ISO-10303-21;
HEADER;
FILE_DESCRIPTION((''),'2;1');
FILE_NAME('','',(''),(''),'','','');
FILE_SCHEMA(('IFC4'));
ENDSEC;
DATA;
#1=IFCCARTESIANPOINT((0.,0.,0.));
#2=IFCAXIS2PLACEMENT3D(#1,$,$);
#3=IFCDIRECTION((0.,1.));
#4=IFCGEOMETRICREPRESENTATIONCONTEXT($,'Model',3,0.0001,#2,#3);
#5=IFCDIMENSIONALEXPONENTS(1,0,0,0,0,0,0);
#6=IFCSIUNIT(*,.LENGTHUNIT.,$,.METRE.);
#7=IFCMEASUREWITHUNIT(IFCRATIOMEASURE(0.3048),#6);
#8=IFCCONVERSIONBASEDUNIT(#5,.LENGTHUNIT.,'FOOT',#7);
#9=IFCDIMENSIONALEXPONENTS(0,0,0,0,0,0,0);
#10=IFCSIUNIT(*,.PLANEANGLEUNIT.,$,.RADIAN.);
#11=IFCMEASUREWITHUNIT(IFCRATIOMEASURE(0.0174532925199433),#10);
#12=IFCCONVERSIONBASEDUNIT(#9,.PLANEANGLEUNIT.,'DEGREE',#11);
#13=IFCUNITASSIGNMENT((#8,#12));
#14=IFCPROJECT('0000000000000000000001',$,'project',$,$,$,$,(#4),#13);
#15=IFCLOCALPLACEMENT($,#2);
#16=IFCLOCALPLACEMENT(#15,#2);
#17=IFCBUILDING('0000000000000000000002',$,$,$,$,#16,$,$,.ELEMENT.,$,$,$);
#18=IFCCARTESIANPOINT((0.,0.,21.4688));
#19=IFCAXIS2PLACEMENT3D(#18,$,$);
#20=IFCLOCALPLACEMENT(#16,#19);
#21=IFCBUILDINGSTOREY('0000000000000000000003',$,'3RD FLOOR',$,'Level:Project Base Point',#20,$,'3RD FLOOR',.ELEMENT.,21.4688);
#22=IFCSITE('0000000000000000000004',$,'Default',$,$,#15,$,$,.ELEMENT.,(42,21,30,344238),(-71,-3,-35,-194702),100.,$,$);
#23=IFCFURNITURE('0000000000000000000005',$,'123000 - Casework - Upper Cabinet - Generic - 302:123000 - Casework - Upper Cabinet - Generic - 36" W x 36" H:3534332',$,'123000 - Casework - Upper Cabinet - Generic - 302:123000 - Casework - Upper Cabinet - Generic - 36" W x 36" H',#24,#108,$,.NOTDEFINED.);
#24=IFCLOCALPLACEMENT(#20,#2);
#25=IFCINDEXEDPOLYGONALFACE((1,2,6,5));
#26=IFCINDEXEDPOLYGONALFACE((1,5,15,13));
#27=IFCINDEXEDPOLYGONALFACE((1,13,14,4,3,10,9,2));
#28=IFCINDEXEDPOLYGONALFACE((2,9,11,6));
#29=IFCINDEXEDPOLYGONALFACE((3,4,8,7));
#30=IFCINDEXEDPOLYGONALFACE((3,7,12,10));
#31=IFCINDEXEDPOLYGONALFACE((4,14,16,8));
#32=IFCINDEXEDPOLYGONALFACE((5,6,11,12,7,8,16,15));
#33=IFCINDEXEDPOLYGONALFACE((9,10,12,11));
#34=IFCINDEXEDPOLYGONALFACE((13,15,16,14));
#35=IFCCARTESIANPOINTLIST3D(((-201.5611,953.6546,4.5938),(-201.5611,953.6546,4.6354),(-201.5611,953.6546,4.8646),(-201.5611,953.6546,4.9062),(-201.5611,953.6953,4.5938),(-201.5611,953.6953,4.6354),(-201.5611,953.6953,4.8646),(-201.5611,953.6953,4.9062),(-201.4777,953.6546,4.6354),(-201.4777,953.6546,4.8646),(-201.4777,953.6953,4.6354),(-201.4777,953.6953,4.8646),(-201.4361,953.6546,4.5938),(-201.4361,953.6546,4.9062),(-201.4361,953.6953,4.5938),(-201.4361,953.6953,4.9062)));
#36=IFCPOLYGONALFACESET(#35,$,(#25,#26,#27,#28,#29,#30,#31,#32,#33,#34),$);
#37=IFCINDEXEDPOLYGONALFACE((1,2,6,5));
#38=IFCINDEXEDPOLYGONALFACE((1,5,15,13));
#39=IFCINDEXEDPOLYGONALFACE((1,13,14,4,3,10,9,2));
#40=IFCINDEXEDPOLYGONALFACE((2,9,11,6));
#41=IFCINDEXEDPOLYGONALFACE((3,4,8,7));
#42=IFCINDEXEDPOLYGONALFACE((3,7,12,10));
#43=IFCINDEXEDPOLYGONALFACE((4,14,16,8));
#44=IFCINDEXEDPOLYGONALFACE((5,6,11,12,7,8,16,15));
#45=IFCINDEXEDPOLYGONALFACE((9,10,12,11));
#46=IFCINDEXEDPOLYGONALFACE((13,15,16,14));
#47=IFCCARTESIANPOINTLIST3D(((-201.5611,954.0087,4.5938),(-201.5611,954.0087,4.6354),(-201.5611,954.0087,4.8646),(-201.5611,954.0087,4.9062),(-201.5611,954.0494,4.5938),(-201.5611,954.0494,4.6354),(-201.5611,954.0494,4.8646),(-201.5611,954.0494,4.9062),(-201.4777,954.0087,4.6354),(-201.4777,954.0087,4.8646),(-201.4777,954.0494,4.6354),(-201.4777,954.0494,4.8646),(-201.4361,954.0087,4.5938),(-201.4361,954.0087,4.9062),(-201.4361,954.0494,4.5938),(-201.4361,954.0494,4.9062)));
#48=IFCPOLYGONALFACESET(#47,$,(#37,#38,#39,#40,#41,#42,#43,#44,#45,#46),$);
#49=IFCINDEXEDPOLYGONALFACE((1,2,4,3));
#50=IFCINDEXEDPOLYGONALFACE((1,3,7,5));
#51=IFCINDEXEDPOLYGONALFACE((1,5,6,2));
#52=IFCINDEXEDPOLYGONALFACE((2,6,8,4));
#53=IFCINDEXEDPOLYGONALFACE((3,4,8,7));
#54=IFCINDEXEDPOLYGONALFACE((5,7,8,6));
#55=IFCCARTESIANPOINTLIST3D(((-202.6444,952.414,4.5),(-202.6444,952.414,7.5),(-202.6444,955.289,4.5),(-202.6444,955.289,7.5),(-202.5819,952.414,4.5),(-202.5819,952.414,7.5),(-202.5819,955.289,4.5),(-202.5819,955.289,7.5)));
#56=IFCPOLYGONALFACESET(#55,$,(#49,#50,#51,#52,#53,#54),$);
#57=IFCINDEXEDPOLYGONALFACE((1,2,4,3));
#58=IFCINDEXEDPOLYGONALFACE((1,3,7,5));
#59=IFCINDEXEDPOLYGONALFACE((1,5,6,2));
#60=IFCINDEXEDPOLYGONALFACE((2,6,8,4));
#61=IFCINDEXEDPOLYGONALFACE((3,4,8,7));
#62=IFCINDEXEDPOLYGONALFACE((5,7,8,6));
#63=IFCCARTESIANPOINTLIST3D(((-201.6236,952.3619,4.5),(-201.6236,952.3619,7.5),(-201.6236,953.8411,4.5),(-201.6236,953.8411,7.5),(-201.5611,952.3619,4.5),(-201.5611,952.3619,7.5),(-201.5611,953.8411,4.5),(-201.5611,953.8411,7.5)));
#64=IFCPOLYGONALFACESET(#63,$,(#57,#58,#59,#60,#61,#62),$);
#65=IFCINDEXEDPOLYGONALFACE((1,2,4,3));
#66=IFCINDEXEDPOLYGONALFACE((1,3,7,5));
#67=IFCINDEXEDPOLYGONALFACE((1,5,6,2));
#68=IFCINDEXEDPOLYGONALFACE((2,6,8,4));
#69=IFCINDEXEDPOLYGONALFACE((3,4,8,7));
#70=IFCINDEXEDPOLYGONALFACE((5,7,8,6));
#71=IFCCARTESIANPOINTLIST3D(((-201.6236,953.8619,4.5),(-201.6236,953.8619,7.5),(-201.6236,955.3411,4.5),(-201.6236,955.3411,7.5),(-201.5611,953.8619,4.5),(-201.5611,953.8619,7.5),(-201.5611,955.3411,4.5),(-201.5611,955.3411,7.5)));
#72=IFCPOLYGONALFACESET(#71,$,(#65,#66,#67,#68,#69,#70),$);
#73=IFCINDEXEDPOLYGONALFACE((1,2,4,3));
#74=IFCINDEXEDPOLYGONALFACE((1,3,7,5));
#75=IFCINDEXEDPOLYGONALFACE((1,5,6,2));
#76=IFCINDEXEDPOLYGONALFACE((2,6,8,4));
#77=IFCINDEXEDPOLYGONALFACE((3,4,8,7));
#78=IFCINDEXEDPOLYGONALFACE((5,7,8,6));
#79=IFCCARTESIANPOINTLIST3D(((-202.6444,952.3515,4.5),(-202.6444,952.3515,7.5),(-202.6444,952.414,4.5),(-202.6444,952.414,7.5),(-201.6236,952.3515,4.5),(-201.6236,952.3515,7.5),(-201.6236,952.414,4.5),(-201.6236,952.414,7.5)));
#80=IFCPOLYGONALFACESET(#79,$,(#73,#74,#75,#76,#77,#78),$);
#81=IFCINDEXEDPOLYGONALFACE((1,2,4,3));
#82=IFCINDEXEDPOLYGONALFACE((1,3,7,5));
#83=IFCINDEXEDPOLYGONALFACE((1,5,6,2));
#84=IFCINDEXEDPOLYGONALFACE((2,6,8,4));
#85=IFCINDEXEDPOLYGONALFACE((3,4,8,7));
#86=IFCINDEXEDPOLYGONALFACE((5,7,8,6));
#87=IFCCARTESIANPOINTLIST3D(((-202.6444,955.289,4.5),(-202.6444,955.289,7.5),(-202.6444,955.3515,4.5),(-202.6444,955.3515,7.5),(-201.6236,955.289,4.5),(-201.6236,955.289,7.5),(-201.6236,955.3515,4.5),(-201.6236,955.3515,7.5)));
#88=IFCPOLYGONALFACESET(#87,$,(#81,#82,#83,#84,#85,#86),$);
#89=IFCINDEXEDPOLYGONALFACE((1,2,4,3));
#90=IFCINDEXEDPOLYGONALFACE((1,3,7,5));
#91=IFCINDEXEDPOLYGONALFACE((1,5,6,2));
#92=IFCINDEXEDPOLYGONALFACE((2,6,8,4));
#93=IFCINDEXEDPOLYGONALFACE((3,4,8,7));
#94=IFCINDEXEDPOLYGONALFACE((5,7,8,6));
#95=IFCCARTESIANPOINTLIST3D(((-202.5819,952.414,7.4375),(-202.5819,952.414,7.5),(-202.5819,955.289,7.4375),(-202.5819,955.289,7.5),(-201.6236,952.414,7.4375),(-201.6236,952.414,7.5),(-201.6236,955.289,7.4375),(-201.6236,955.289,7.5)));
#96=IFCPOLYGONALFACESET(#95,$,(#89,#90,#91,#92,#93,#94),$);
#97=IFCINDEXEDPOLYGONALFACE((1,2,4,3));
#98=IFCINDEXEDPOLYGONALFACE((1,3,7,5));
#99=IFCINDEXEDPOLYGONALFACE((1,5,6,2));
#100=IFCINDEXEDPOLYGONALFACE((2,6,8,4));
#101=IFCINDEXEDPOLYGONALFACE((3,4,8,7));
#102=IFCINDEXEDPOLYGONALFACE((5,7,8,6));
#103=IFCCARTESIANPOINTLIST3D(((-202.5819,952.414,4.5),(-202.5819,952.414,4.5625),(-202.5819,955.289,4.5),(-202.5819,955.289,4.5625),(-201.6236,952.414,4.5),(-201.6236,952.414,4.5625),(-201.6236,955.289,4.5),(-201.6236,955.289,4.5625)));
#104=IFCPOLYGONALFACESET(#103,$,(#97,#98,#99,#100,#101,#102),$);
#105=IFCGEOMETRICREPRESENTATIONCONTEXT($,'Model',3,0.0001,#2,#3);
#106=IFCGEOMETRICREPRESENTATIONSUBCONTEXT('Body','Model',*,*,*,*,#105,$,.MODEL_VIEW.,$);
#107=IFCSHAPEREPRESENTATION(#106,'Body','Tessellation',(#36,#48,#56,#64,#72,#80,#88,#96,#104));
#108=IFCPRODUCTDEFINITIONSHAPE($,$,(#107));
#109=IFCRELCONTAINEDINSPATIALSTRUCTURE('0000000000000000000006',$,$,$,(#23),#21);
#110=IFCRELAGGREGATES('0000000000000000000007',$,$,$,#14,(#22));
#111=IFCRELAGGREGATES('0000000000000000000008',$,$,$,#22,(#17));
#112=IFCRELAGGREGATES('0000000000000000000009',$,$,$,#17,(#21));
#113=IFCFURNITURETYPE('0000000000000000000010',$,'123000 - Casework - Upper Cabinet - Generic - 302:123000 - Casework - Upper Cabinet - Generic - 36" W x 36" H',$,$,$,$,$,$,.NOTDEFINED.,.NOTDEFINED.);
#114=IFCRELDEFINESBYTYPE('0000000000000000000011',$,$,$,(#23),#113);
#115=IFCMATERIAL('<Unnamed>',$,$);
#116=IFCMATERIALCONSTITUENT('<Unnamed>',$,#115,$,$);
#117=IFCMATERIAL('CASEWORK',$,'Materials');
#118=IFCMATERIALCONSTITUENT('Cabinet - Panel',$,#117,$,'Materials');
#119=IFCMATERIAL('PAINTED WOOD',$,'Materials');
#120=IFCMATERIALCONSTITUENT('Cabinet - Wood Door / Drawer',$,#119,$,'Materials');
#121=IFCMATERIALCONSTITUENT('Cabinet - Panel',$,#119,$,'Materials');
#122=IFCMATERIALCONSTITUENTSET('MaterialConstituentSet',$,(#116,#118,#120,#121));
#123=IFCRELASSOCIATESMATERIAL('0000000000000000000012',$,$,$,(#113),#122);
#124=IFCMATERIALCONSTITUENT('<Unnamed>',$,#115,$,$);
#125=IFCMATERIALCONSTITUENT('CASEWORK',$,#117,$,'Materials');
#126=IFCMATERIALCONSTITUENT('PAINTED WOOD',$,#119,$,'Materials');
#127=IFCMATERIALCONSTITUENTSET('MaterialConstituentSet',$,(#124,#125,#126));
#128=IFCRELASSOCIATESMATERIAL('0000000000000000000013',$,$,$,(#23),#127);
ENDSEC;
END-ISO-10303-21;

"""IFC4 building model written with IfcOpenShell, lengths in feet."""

from ifc_helpers import new_model, entity, si_unit, converted_unit, direction, frame, frame_2d, origin, origin_2d_with_axis, place, context, subcontext, project, spatial, polyline, rectangle, outline, extrude, source, transform, mapped, material, constituent, constituent_set, type_object, type_shapes, element, save


model = new_model("IFC4")

# Units and contexts
model_context_1 = context("Model", 3, precision=0.0001, world=origin(), true_north=direction((0.0, 1.0)))
model_context_2 = context("Model", 3, precision=0.0001, world=origin(), true_north=direction((0.0, 1.0)))
body_context = subcontext(model_context_2, "Body", "Model", "MODEL_VIEW")
ifc_project = project(units=[converted_unit("LENGTHUNIT", "FOOT", entity("IfcRatioMeasure", 0.3048), si_unit("LENGTHUNIT", "METRE"), dimensions=[1, 0, 0, 0, 0, 0, 0]), converted_unit("PLANEANGLEUNIT", "DEGREE", entity("IfcRatioMeasure", 0.0174532925199433), si_unit("PLANEANGLEUNIT", "RADIAN"), dimensions=[0, 0, 0, 0, 0, 0, 0])], contexts=[model_context_1])

# Site, building, storey
site_placement = place(None, origin())
site = spatial("IfcSite", under=ifc_project, at=site_placement, Name="Default", CompositionType="ELEMENT", RefLatitude=(42, 21, 30, 344238), RefLongitude=(-71, -3, -35, -194702), RefElevation=100.0)
building_placement = place(site_placement, origin())
building = spatial("IfcBuilding", under=site, at=building_placement, CompositionType="ELEMENT")
storey_placement = place(building_placement, frame((0.0, 0.0, 21.4688)))
storey = spatial("IfcBuildingStorey", under=building, at=storey_placement, Name="3RD FLOOR", ObjectType="Level:Project Base Point", LongName="3RD FLOOR", CompositionType="ELEMENT", Elevation=21.4688)

# Furniture
ifc_material_1 = material(Name="CASEWORK", Category="Materials")
ifc_material_2 = material(Name="PAINTED WOOD", Category="Materials")
ifc_material_3 = material(Name="<Unnamed>")
ifc_constituent_1 = constituent(ifc_material_3, Name="<Unnamed>")
ifc_constituent_2 = constituent(ifc_material_1, Name="CASEWORK", Category="Materials")
ifc_constituent_3 = constituent(ifc_material_2, Name="PAINTED WOOD", Category="Materials")
ifc_constituent_set_1 = constituent_set(constituents=[ifc_constituent_1, ifc_constituent_2, ifc_constituent_3], Name="MaterialConstituentSet")
ifc_constituent_4 = constituent(ifc_material_3, Name="<Unnamed>")
ifc_constituent_5 = constituent(ifc_material_1, Name="Cabinet - Panel", Category="Materials")
ifc_constituent_6 = constituent(ifc_material_2, Name="Cabinet - Wood Door / Drawer", Category="Materials")
ifc_constituent_7 = constituent(ifc_material_2, Name="Cabinet - Panel", Category="Materials")
ifc_constituent_set_2 = constituent_set(constituents=[ifc_constituent_4, ifc_constituent_5, ifc_constituent_6, ifc_constituent_7], Name="MaterialConstituentSet")
furniture_type_1 = type_object("IfcFurnitureType", Name="123000 - Casework - Upper Cabinet - Generic - 302:123000 - Casework - Upper Cabinet - Generic - 36\" W x 36\" H", AssemblyPlace="NOTDEFINED", PredefinedType="NOTDEFINED", material=ifc_constituent_set_2)
shared_shape_1 = source(origin(), body_context, "Body", "SweptSolid", [
    extrude(outline(polyline([(0.1146, -0.0521), (0.1562, -0.0521), (0.1562, 0.0729), (-0.1562, 0.0729), (-0.1562, -0.0521), (-0.1146, -0.0521), (-0.1146, 0.0313), (0.1146, 0.0313), (0.1146, -0.0521)])), frame((1.303, 0.0729, 0.25), z_axis=(1.0, 0.0, 0.0), x_axis=(0.0, 0.0, 1.0)), (0.0, 0.0, 1.0), 0.0407),
    extrude(outline(polyline([(0.1146, -0.0521), (0.1562, -0.0521), (0.1562, 0.0729), (-0.1562, 0.0729), (-0.1562, -0.0521), (-0.1146, -0.0521), (-0.1146, 0.0313), (0.1146, 0.0313), (0.1146, -0.0521)])), frame((1.6572, 0.0729, 0.25), z_axis=(1.0, 0.0, 0.0), x_axis=(0.0, 0.0, 1.0)), (0.0, 0.0, 1.0), 0.0407),
    extrude(rectangle(XDim=0.0625, YDim=2.875, at=origin_2d_with_axis()), frame((1.5, 1.177, 0.0), z_axis=(0.0, 0.0, 1.0), x_axis=(0.0, 1.0, 0.0)), (0.0, 0.0, 1.0), 3.0),
    extrude(rectangle(XDim=0.0625, YDim=1.4792, at=frame_2d((0.0, 0.0), x_axis=(1.0, 0.0))), frame((0.75, 0.1562, 0.0), z_axis=(0.0, 0.0, 1.0), x_axis=(0.0, -1.0, 0.0)), (0.0, 0.0, 1.0), 3.0),
    extrude(rectangle(XDim=0.0625, YDim=1.4792, at=origin_2d_with_axis()), frame((2.25, 0.1562, 0.0), z_axis=(0.0, 0.0, 1.0), x_axis=(0.0, -1.0, 0.0)), (0.0, 0.0, 1.0), 3.0),
    extrude(rectangle(XDim=0.0625, YDim=1.0208, at=origin_2d_with_axis()), frame((0.0312, 0.6979, 0.0), z_axis=(0.0, 0.0, 1.0), x_axis=(-1.0, 0.0, 0.0)), (0.0, 0.0, 1.0), 3.0),
    extrude(rectangle(XDim=0.0625, YDim=1.0208, at=origin_2d_with_axis()), frame((2.9688, 0.6979, 0.0), z_axis=(0.0, 0.0, 1.0), x_axis=(-1.0, 0.0, 0.0)), (0.0, 0.0, 1.0), 3.0),
    extrude(rectangle(XDim=2.875, YDim=0.9583, at=frame_2d((0.0, 0.0), x_axis=(1.0, 0.0))), frame((1.5, 0.6666, 2.9375), z_axis=(0.0, 0.0, 1.0), x_axis=(-1.0, 0.0, 0.0)), (0.0, 0.0, 1.0), 0.0625),
    extrude(rectangle(XDim=2.875, YDim=0.9583, at=frame_2d((0.0, 0.0), x_axis=(1.0, 0.0))), frame((1.5, 0.6666, 0.0), z_axis=(0.0, 0.0, 1.0), x_axis=(-1.0, 0.0, 0.0)), (0.0, 0.0, 1.0), 0.0625),
])
type_shapes(furniture_type_1, [shared_shape_1])
furniture_1_placement = place(storey_placement, frame((-201.4361, 952.3515, 4.5), z_axis=(0.0, 0.0, 1.0), x_axis=(0.0, 1.0, 0.0)))
element("IfcFurniture", 1, at=furniture_1_placement, inside=storey, type_object=furniture_type_1, material=ifc_constituent_set_1, Name="123000 - Casework - Upper Cabinet - Generic - 302:123000 - Casework - Upper Cabinet - Generic - 36\" W x 36\" H:3534332", ObjectType="123000 - Casework - Upper Cabinet - Generic - 302:123000 - Casework - Upper Cabinet - Generic - 36\" W x 36\" H", PredefinedType="NOTDEFINED", context=body_context, shape_type="MappedRepresentation", body=[
    mapped(shared_shape_1, transform((0.0, 0.0, 0.0), scale=1.0)),
])

save(model, "model.ifc")
